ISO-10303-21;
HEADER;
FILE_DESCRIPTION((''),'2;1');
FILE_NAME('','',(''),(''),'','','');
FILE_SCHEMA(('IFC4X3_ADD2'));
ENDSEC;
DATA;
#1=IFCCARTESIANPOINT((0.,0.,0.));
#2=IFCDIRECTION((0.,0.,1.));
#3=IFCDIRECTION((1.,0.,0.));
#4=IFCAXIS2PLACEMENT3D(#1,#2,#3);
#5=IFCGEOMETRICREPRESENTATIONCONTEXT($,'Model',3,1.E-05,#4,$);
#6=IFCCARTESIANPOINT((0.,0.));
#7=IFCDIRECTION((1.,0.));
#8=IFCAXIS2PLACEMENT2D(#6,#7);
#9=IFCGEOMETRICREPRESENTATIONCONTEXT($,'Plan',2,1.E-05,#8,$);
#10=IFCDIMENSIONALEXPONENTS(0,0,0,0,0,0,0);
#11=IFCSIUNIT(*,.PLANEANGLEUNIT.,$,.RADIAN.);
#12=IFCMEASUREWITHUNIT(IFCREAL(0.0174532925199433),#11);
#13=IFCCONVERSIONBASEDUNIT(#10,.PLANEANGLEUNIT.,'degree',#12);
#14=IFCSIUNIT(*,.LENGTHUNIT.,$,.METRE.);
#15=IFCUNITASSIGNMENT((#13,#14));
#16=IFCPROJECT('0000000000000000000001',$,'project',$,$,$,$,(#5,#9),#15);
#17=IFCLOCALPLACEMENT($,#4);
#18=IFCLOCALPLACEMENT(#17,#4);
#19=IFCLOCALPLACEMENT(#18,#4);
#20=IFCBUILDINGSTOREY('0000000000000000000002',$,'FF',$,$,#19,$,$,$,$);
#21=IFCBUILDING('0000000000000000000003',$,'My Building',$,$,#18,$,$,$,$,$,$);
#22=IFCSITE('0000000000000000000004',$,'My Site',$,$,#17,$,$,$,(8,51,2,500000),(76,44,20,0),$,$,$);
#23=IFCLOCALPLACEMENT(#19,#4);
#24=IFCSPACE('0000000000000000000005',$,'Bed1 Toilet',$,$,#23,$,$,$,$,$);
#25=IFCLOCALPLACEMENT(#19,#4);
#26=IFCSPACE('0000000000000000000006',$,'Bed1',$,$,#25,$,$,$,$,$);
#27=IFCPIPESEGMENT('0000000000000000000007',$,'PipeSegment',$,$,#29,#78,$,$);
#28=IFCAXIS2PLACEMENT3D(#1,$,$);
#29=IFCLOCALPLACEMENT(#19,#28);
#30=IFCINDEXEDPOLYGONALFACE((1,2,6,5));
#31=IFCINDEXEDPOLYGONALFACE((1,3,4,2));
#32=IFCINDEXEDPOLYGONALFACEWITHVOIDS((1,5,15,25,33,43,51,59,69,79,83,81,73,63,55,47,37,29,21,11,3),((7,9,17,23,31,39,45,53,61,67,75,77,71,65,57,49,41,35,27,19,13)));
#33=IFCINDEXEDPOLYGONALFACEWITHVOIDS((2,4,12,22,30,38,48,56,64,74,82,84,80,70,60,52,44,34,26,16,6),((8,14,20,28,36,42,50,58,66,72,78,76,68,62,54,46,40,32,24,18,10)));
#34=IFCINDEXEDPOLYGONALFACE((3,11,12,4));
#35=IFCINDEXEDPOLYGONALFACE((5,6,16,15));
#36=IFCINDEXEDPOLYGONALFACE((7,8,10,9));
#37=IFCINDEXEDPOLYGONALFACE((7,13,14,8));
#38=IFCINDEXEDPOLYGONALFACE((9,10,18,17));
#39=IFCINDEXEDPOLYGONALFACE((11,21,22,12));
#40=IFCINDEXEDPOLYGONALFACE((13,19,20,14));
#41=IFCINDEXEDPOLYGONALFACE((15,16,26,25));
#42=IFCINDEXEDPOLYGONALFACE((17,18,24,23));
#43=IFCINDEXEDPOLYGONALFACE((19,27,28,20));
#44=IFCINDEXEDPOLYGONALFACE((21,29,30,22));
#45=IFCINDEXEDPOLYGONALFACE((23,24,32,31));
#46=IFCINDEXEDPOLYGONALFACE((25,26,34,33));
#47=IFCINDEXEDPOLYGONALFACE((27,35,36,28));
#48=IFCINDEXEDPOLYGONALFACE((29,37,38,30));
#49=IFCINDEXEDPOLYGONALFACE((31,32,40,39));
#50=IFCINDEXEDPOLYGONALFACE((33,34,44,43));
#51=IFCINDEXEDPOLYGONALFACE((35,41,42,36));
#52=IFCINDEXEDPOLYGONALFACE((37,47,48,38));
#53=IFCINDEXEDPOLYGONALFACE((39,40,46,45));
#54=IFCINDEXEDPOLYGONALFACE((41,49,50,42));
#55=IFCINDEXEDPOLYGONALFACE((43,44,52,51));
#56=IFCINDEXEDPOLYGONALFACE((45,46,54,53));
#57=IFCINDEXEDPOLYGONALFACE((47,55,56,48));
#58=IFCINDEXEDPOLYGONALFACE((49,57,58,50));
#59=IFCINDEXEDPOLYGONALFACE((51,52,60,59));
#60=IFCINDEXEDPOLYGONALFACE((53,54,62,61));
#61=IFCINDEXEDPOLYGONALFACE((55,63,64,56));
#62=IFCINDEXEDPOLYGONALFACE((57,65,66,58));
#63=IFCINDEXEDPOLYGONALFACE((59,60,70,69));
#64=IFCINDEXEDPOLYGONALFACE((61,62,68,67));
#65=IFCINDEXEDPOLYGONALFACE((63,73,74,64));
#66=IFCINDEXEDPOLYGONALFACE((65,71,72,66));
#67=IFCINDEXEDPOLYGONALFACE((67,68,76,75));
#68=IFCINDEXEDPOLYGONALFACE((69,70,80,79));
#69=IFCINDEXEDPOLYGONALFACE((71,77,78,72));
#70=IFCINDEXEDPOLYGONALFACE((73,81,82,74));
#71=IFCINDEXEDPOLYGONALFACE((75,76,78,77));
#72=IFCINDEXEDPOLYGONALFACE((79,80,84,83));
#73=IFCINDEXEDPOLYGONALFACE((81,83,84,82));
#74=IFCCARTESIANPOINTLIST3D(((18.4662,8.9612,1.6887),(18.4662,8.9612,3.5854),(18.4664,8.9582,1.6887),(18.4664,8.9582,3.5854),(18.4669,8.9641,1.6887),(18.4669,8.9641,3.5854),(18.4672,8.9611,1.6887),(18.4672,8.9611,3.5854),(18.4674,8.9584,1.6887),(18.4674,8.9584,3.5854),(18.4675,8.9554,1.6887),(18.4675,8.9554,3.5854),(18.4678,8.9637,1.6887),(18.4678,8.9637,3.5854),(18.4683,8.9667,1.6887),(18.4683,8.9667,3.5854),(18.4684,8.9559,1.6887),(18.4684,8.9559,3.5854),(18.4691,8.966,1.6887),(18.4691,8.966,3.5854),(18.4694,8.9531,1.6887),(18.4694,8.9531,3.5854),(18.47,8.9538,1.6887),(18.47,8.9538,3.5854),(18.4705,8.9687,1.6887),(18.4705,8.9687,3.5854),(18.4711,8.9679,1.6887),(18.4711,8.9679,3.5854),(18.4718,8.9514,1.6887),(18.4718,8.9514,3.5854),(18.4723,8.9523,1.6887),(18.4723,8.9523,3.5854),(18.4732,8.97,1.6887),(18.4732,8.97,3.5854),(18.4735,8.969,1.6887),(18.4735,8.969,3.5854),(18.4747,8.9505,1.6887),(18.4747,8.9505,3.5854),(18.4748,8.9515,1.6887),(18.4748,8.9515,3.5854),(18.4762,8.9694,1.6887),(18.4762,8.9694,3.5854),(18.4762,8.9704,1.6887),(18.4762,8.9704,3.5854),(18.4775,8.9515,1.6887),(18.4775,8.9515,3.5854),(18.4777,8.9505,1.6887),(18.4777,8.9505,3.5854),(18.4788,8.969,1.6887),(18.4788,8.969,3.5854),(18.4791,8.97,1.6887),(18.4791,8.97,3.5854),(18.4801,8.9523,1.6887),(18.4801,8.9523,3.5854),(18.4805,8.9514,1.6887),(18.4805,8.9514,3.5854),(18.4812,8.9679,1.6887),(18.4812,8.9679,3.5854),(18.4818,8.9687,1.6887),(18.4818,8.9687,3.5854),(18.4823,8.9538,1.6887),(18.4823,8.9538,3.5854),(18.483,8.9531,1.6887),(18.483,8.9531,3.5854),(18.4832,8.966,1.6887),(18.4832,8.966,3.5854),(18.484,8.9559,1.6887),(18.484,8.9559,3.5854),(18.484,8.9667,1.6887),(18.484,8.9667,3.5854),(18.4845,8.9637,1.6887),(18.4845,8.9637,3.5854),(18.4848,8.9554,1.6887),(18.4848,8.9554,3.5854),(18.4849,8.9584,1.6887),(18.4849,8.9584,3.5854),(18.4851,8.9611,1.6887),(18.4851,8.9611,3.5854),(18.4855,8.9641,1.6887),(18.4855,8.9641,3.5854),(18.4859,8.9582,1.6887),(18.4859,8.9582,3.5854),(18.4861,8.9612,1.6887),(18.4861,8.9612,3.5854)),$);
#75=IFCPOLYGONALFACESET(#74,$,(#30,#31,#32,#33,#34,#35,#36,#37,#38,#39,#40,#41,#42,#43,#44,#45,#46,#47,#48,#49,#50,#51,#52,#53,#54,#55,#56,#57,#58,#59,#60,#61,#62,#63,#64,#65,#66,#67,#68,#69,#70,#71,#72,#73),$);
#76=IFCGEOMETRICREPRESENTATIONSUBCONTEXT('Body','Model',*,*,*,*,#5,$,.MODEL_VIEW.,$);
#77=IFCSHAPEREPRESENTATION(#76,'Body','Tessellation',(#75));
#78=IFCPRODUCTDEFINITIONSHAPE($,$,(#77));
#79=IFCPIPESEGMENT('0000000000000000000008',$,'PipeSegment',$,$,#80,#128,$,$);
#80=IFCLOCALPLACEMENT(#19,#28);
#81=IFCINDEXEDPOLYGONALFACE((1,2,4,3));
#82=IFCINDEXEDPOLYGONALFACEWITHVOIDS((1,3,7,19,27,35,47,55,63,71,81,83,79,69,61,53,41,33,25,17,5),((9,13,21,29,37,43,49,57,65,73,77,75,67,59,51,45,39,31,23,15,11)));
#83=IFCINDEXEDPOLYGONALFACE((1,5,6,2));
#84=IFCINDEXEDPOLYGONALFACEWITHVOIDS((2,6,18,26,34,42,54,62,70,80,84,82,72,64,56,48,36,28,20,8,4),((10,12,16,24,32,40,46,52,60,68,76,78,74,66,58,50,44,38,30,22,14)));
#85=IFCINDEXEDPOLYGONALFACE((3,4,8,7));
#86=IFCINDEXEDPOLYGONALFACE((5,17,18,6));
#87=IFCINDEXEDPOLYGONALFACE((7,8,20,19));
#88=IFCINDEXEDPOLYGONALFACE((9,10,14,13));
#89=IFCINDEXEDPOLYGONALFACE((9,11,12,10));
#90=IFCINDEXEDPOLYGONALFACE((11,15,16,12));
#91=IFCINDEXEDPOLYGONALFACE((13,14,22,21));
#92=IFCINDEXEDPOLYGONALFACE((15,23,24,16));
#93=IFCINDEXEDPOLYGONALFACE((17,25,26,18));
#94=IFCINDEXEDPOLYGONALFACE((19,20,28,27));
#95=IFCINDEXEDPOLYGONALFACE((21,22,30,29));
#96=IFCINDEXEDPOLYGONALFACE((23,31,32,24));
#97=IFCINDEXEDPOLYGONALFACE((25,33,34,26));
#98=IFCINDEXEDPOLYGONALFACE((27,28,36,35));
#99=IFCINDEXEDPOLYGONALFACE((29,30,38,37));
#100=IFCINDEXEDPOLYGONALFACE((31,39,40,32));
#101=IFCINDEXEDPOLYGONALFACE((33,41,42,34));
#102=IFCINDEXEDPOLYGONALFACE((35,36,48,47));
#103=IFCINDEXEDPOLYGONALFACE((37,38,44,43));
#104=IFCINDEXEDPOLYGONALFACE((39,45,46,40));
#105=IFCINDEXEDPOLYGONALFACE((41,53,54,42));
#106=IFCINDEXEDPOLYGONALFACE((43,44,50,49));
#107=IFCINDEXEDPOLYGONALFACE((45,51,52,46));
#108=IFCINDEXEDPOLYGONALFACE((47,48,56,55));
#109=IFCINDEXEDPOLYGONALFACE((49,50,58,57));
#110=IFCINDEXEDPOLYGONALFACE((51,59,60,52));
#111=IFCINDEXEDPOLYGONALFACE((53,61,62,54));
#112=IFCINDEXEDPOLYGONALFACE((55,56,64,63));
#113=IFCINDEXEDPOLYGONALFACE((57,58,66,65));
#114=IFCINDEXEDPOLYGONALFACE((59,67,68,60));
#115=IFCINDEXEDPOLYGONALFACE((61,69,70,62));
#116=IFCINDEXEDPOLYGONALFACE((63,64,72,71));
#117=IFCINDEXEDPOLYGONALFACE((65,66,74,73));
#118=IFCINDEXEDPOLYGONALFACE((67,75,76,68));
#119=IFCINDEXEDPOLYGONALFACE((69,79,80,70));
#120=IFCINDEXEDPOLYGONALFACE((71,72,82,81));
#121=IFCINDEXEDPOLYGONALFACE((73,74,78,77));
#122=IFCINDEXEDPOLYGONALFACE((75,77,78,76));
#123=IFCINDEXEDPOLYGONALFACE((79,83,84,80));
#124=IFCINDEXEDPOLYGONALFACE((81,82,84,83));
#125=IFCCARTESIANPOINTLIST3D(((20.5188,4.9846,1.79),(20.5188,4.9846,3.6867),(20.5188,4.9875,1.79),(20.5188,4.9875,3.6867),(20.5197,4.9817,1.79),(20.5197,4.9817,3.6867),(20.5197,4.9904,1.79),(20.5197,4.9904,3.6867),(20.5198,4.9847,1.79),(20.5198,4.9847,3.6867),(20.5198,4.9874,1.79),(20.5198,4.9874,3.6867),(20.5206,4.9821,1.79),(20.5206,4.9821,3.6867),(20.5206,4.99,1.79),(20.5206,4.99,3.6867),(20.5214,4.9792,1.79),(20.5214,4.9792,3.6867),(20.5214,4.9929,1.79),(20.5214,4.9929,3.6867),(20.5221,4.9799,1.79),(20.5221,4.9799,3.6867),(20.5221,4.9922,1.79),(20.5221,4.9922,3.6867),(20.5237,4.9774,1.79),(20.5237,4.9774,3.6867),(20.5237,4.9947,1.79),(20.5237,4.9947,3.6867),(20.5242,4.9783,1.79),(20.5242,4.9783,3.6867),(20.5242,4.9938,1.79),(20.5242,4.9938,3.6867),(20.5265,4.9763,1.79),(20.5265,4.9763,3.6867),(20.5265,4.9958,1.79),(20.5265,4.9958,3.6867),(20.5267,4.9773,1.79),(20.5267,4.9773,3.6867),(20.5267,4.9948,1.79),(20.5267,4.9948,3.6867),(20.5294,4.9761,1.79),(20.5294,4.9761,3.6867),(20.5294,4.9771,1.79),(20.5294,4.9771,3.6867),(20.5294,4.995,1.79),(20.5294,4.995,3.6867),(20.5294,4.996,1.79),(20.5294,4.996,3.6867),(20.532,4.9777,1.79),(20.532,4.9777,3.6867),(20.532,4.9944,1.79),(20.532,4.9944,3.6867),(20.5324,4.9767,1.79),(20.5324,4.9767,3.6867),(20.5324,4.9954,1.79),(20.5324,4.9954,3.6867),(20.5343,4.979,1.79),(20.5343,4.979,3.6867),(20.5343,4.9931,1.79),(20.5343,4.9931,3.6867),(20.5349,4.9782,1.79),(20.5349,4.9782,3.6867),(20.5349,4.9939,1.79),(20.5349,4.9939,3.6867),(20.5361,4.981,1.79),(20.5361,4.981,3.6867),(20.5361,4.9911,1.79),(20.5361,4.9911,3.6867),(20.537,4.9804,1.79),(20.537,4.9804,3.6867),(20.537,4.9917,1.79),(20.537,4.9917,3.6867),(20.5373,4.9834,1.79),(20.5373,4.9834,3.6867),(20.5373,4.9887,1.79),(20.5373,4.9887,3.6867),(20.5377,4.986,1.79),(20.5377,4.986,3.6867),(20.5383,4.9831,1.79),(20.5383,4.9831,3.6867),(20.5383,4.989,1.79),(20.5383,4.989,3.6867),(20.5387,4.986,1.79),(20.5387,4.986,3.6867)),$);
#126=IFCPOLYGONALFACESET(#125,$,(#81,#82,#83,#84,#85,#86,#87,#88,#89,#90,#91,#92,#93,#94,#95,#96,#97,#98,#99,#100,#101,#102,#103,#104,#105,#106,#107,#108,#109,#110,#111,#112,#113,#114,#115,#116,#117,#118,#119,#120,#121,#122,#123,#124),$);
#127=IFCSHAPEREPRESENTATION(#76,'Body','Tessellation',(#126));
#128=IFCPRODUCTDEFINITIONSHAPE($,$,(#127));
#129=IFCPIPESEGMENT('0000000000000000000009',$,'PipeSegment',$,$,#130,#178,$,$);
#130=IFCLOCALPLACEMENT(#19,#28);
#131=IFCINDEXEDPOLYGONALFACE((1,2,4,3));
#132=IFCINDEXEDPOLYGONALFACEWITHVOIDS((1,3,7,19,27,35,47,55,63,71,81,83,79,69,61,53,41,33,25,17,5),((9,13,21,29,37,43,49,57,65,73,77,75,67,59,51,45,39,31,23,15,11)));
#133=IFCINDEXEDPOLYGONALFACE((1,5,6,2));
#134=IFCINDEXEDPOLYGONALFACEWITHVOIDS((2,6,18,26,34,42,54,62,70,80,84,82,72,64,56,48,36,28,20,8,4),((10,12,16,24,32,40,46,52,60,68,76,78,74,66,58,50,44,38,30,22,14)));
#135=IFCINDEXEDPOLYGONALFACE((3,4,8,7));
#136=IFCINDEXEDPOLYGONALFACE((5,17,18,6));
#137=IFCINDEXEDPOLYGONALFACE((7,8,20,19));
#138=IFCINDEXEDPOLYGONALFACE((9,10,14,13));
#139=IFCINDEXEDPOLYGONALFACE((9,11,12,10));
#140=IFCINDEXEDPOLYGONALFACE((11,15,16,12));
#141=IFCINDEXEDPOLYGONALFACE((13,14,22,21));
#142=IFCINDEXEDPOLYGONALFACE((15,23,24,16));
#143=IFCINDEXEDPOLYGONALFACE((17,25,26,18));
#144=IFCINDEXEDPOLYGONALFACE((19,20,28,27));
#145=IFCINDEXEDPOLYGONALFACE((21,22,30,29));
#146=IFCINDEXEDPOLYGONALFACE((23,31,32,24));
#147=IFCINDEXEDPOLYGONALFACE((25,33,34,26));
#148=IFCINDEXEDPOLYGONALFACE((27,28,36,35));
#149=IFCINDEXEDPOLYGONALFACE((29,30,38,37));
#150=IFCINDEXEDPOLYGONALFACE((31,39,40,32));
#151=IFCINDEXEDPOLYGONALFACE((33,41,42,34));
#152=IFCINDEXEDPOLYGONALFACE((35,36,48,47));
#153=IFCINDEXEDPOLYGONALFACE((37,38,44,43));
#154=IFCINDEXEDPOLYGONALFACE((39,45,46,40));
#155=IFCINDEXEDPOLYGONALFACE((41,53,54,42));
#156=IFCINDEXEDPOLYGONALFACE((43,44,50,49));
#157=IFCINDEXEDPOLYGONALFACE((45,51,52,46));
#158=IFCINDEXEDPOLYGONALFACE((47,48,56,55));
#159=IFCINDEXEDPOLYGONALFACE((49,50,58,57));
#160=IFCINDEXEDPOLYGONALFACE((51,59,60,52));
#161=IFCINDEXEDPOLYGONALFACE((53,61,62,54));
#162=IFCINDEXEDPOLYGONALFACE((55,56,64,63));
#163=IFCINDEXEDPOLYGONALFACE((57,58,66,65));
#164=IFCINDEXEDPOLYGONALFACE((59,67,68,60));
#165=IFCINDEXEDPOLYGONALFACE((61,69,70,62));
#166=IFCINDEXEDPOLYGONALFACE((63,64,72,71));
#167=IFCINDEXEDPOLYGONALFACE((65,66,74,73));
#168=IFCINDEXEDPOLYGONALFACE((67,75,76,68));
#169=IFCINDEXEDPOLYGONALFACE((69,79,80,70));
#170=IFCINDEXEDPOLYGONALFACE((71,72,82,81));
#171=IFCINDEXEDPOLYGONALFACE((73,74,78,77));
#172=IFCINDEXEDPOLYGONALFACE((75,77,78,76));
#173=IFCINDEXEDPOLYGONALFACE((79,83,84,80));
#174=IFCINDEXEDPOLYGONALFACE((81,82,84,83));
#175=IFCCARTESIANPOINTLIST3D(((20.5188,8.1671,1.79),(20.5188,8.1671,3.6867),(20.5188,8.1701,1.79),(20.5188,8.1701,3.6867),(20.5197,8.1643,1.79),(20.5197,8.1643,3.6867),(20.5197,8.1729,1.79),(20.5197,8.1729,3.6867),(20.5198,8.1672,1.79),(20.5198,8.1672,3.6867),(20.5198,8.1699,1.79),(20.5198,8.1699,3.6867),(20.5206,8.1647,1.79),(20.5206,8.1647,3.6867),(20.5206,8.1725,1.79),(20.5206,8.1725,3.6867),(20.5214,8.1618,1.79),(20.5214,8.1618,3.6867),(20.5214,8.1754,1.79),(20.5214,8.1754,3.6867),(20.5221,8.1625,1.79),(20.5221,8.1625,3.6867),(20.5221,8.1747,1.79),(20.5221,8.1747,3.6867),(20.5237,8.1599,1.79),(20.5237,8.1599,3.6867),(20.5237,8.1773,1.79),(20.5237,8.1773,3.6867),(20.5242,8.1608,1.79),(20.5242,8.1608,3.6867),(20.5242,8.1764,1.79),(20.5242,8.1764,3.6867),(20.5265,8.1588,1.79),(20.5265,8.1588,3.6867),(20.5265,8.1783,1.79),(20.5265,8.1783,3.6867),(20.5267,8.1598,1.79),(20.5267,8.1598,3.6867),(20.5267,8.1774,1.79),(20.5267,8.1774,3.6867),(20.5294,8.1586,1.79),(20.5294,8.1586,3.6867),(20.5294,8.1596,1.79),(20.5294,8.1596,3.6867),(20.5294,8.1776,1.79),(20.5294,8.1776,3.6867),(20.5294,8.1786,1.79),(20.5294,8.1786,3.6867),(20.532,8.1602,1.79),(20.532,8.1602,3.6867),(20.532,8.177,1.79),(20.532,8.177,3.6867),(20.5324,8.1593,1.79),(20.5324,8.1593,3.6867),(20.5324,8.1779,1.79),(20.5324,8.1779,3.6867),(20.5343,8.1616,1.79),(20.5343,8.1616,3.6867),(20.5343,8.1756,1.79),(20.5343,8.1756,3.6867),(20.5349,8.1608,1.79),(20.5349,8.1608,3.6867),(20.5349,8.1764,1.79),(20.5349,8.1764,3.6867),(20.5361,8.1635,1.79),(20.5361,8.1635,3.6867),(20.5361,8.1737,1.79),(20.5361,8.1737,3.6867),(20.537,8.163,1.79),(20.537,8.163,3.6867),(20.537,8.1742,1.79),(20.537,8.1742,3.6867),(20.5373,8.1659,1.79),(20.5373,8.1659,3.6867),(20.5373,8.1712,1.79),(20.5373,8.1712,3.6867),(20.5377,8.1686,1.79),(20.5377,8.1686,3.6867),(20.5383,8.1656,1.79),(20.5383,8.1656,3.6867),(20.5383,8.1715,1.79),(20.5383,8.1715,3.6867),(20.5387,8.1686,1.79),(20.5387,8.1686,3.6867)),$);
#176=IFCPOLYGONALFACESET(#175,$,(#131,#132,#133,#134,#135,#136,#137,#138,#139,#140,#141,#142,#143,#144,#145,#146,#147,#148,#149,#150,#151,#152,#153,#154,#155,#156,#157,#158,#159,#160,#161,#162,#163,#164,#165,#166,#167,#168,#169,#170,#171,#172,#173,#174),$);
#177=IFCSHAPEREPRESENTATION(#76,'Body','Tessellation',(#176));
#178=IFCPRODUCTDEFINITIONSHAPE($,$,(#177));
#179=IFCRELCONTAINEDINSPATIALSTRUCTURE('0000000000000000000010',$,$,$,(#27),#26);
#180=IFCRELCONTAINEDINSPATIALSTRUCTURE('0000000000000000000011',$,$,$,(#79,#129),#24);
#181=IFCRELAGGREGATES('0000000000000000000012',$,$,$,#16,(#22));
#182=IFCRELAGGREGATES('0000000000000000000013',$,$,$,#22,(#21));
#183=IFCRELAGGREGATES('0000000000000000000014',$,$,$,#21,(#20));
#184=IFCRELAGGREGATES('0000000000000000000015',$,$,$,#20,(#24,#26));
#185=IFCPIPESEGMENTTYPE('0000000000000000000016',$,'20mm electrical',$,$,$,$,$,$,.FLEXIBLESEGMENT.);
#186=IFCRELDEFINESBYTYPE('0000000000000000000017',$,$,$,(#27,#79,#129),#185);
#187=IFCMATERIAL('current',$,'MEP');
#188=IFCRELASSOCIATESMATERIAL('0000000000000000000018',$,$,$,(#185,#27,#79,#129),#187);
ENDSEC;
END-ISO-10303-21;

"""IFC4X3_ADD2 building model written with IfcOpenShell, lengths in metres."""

from ifc_helpers import new_model, entity, si_unit, converted_unit, frame, origin_with_axes, origin_2d_with_axis, place, context, subcontext, project, spatial, hollow_circle, extrude, material, material_profile, profile_set, profile_usage, type_object, element, save


model = new_model("IFC4X3_ADD2")

# Units and contexts
model_context = context("Model", 3, precision=1e-05, world=origin_with_axes())
plan_context = context("Plan", 2, precision=1e-05, world=origin_2d_with_axis())
body_context_1 = subcontext(model_context, "Body", "Model", "MODEL_VIEW")
ifc_project = project(units=[converted_unit("PLANEANGLEUNIT", "degree", entity("IfcReal", 0.0174532925199433), si_unit("PLANEANGLEUNIT", "RADIAN"), dimensions=[0, 0, 0, 0, 0, 0, 0]), si_unit("LENGTHUNIT", "METRE")], contexts=[model_context, plan_context])

# Site, building, storey
site_placement = place(None, origin_with_axes())
site = spatial("IfcSite", under=ifc_project, at=site_placement, Name="My Site", RefLatitude=(8, 51, 2, 500000), RefLongitude=(76, 44, 20, 0))
building_placement = place(site_placement, origin_with_axes())
building = spatial("IfcBuilding", under=site, at=building_placement, Name="My Building")
storey_placement = place(building_placement, origin_with_axes())
storey = spatial("IfcBuildingStorey", under=building, at=storey_placement, Name="FF")

# Shared definitions
space_1_placement = place(storey_placement, origin_with_axes())
space_1 = spatial("IfcSpace", under=storey, at=space_1_placement, Name="Bed1 Toilet")

# Shared definitions
space_2_placement = place(storey_placement, origin_with_axes())
space_2 = spatial("IfcSpace", under=storey, at=space_2_placement, Name="Bed1")

# Pipe segments
ifc_material_1 = material(Name="current", Category="MEP")
ifc_material_profile_1 = material_profile(ifc_material_1, hollow_circle(Radius=0.01, WallThickness=0.001))
ifc_profile_set_1 = profile_set([ifc_material_profile_1], Name="current")
pipe_segment_type = type_object("IfcPipeSegmentType", Name="20mm electrical", PredefinedType="FLEXIBLESEGMENT", material=ifc_profile_set_1)
ifc_profile_usage_1 = profile_usage(ifc_profile_set_1, cardinal=5)
pipe_segment_1_placement = place(space_2_placement, frame((18.4762, 8.9604, 1.6887), z_axis=(0.0, 0.0, 1.0), x_axis=(0.0, 1.0, 0.0)))
element("IfcPipeSegment", 1, at=pipe_segment_1_placement, inside=space_2, type_object=pipe_segment_type, material=ifc_profile_usage_1, Name="PipeSegment", context=body_context_1, shape_type="SweptSolid", body=[
    extrude(hollow_circle(Radius=0.01, WallThickness=0.001), origin_with_axes(), (0.0, 0.0, 1.0), 1.8967),
])
ifc_profile_usage_2 = profile_usage(ifc_profile_set_1, cardinal=5)
pipe_segment_2_placement = place(space_1_placement, frame((20.5287, 4.986, 1.79), z_axis=(0.0, 0.0, 1.0), x_axis=(1.0, 0.0, 0.0)))
element("IfcPipeSegment", 2, at=pipe_segment_2_placement, inside=space_1, type_object=pipe_segment_type, material=ifc_profile_usage_2, Name="PipeSegment", context=body_context_1, shape_type="SweptSolid", body=[
    extrude(hollow_circle(Radius=0.01, WallThickness=0.001), origin_with_axes(), (0.0, 0.0, 1.0), 1.8967),
])
ifc_profile_usage_3 = profile_usage(ifc_profile_set_1, cardinal=5)
pipe_segment_3_placement = place(space_1_placement, frame((20.5287, 8.1686, 1.79), z_axis=(0.0, 0.0, 1.0), x_axis=(1.0, 0.0, 0.0)))
element("IfcPipeSegment", 3, at=pipe_segment_3_placement, inside=space_1, type_object=pipe_segment_type, material=ifc_profile_usage_3, Name="PipeSegment", context=body_context_1, shape_type="SweptSolid", body=[
    extrude(hollow_circle(Radius=0.01, WallThickness=0.001), origin_with_axes(), (0.0, 0.0, 1.0), 1.8967),
])

save(model, "model.ifc")
